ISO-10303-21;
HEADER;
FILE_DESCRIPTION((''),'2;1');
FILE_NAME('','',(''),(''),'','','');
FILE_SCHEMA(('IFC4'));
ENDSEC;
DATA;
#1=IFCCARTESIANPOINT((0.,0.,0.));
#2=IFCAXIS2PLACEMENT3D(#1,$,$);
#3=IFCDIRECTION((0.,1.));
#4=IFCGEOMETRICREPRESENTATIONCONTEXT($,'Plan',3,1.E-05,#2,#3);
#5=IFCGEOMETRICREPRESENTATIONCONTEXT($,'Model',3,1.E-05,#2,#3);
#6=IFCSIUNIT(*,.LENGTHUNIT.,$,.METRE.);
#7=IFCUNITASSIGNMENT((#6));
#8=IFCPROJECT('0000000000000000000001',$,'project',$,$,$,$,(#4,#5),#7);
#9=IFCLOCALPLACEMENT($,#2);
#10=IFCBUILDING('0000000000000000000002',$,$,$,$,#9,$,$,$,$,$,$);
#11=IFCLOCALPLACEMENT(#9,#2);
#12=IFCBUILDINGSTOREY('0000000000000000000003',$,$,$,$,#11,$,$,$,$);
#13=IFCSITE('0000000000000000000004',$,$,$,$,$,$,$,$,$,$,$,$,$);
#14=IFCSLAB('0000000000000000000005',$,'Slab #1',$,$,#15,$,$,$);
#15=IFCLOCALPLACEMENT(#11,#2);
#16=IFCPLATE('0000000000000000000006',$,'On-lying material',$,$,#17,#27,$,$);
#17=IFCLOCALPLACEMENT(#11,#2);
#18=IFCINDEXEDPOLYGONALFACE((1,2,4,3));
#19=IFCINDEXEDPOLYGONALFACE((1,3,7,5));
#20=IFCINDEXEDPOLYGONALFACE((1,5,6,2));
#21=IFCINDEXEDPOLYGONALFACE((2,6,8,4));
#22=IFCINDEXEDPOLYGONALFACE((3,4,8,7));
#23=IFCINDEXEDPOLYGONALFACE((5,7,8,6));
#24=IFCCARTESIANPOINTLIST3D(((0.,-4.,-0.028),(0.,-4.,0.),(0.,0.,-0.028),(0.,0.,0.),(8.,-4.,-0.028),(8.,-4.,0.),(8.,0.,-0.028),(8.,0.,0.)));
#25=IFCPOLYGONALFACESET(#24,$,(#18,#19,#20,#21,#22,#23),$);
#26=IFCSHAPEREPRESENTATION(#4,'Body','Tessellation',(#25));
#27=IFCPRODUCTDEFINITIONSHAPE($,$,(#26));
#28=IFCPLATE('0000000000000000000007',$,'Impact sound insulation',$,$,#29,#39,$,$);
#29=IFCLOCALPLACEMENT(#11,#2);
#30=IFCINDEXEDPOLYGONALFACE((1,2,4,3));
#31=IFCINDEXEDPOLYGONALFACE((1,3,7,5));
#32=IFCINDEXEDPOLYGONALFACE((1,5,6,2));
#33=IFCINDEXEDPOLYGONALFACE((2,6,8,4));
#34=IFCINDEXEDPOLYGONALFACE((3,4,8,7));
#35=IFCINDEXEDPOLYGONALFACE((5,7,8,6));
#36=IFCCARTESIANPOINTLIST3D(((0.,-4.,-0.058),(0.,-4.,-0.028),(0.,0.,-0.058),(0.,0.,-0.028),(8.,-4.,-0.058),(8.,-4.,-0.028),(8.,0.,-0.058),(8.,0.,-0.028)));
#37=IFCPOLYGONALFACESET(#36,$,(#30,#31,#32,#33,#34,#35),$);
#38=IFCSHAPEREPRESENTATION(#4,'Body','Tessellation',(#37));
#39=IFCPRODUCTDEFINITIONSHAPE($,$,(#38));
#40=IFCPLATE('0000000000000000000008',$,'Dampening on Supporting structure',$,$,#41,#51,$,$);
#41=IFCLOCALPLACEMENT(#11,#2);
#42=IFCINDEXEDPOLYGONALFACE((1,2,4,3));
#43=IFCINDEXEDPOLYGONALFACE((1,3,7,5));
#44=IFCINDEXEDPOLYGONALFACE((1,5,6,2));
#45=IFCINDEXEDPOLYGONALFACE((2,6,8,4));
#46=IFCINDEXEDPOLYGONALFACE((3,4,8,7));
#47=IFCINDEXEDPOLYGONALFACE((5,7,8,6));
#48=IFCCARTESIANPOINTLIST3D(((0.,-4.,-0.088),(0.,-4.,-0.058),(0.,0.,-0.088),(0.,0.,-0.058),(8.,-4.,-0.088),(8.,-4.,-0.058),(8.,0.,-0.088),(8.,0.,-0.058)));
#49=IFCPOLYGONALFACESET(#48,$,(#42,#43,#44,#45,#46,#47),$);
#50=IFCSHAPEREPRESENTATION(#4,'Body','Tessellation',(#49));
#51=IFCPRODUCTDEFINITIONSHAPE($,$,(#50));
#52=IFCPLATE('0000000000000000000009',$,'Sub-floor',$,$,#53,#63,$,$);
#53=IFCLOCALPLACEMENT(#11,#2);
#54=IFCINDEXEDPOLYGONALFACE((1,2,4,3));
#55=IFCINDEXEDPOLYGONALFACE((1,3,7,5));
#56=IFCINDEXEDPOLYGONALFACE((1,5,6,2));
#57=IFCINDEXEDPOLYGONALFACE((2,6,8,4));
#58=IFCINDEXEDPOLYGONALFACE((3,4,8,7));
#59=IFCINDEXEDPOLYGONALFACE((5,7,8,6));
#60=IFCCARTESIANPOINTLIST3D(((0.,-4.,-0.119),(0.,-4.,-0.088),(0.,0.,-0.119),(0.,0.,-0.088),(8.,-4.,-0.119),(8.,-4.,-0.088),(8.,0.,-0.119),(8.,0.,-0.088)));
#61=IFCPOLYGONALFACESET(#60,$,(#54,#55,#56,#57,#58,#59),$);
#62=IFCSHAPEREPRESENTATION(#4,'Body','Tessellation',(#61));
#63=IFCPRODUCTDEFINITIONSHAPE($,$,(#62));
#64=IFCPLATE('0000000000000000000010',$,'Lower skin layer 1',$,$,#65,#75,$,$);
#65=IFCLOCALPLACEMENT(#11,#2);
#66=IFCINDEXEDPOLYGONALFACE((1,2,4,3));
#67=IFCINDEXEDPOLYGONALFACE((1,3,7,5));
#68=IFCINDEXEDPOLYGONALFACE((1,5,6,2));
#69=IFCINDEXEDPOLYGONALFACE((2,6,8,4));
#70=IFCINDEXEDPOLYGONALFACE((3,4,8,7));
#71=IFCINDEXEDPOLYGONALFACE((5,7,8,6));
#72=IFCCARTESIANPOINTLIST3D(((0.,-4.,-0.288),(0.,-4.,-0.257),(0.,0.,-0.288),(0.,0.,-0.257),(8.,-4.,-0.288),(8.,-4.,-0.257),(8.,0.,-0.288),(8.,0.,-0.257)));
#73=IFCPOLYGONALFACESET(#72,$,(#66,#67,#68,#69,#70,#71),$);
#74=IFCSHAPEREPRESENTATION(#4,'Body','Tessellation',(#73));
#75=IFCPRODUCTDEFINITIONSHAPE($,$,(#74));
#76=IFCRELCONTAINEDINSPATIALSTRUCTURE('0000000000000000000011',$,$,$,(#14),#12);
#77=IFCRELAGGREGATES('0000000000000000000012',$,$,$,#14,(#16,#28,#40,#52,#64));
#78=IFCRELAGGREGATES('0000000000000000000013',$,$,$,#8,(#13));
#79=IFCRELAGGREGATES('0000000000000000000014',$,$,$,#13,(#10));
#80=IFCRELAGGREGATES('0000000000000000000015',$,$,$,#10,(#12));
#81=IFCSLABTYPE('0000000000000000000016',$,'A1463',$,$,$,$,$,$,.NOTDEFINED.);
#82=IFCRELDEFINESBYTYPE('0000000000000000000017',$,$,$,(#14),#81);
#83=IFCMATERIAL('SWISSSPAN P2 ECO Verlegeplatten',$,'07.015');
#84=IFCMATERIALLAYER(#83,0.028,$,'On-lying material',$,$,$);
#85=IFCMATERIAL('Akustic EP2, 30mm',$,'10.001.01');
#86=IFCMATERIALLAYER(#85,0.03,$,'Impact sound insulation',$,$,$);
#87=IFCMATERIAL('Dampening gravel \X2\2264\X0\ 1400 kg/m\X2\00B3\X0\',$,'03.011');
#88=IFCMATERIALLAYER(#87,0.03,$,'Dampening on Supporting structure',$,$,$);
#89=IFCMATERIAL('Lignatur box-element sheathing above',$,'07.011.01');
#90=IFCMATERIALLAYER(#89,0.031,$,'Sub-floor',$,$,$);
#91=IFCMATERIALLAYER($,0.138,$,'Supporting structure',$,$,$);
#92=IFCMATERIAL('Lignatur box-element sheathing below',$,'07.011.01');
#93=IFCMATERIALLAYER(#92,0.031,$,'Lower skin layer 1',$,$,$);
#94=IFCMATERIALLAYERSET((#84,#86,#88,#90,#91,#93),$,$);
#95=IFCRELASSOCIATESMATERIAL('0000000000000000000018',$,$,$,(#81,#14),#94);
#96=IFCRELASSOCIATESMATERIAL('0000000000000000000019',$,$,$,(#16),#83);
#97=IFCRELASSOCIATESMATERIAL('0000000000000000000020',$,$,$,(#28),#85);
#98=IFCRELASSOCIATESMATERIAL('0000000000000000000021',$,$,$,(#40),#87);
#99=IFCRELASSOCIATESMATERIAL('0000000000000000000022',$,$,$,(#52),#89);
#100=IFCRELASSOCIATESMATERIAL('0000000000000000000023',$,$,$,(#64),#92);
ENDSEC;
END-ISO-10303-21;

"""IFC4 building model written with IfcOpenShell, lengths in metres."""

from ifc_helpers import new_model, si_unit, direction, frame, frame_2d, origin, origin_with_axes, place, context, project, spatial, rectangle, extrude, material, layer, layer_set, type_object, element, aggregate, save


model = new_model("IFC4")

# Units and contexts
plan_context = context("Plan", 3, precision=1e-05, world=origin(), true_north=direction((0.0, 1.0)))
model_context = context("Model", 3, precision=1e-05, world=origin(), true_north=direction((0.0, 1.0)))
ifc_project = project(units=[si_unit("LENGTHUNIT", "METRE")], contexts=[plan_context, model_context])

# Site, building, storey
site = spatial("IfcSite", under=ifc_project)
building_placement = place(None, origin())
building = spatial("IfcBuilding", under=site, at=building_placement)
storey_placement = place(building_placement, origin())
storey = spatial("IfcBuildingStorey", under=building, at=storey_placement)

# Slab, plates
ifc_material_1 = material(Name="SWISSSPAN P2 ECO Verlegeplatten", Category="07.015")
ifc_layer_1 = layer(ifc_material_1, 0.028, Name="On-lying material")
ifc_material_2 = material(Name="Akustic EP2, 30mm", Category="10.001.01")
ifc_layer_2 = layer(ifc_material_2, 0.03, Name="Impact sound insulation")
ifc_material_3 = material(Name="Dampening gravel ≤ 1400 kg/m³", Category="03.011")
ifc_layer_3 = layer(ifc_material_3, 0.03, Name="Dampening on Supporting structure")
ifc_material_4 = material(Name="Lignatur box-element sheathing above", Category="07.011.01")
ifc_layer_4 = layer(ifc_material_4, 0.031, Name="Sub-floor")
ifc_layer_5 = layer(None, 0.138, Name="Supporting structure")
ifc_material_5 = material(Name="Lignatur box-element sheathing below", Category="07.011.01")
ifc_layer_6 = layer(ifc_material_5, 0.031, Name="Lower skin layer 1")
ifc_layer_set = layer_set([ifc_layer_1, ifc_layer_2, ifc_layer_3, ifc_layer_4, ifc_layer_5, ifc_layer_6])
slab_type = type_object("IfcSlabType", Name="A1463", PredefinedType="NOTDEFINED", material=ifc_layer_set)
slab_placement = place(None, frame((0.0, 0.0, 0.0), z_axis=(0.0, 0.0, -1.0), x_axis=(1.0, 0.0, 0.0)))
slab = element("IfcSlab", 1, at=slab_placement, inside=storey, type_object=slab_type, material=ifc_layer_set, Name="Slab #1")
plate_1_placement = place(slab_placement, origin())
plate_1 = element("IfcPlate", 2, at=plate_1_placement, material=ifc_material_1, Name="On-lying material", context=plan_context, shape_type="SweptSolid", body=[
    extrude(rectangle(XDim=8.0, YDim=4.0, at=frame_2d((4.0, 2.0), x_axis=(1.0, 0.0))), origin_with_axes(), (0.0, 0.0, 1.0), 0.028),
])
plate_2_placement = place(slab_placement, origin())
plate_2 = element("IfcPlate", 3, at=plate_2_placement, material=ifc_material_2, Name="Impact sound insulation", context=plan_context, shape_type="SweptSolid", body=[
    extrude(rectangle(XDim=8.0, YDim=4.0, at=frame_2d((4.0, 2.0), x_axis=(1.0, 0.0))), frame((0.0, 0.0, 0.028), z_axis=(0.0, 0.0, 1.0), x_axis=(1.0, 0.0, 0.0)), (0.0, 0.0, 1.0), 0.03),
])
plate_3_placement = place(slab_placement, origin())
plate_3 = element("IfcPlate", 4, at=plate_3_placement, material=ifc_material_3, Name="Dampening on Supporting structure", context=plan_context, shape_type="SweptSolid", body=[
    extrude(rectangle(XDim=8.0, YDim=4.0, at=frame_2d((4.0, 2.0), x_axis=(1.0, 0.0))), frame((0.0, 0.0, 0.058), z_axis=(0.0, 0.0, 1.0), x_axis=(1.0, 0.0, 0.0)), (0.0, 0.0, 1.0), 0.03),
])
plate_4_placement = place(slab_placement, origin())
plate_4 = element("IfcPlate", 5, at=plate_4_placement, material=ifc_material_4, Name="Sub-floor", context=plan_context, shape_type="SweptSolid", body=[
    extrude(rectangle(XDim=8.0, YDim=4.0, at=frame_2d((4.0, 2.0), x_axis=(1.0, 0.0))), frame((0.0, 0.0, 0.088), z_axis=(0.0, 0.0, 1.0), x_axis=(1.0, 0.0, 0.0)), (0.0, 0.0, 1.0), 0.031),
])
plate_5_placement = place(slab_placement, origin())
plate_5 = element("IfcPlate", 6, at=plate_5_placement, material=ifc_material_5, Name="Lower skin layer 1", context=plan_context, shape_type="SweptSolid", body=[
    extrude(rectangle(XDim=8.0, YDim=4.0, at=frame_2d((4.0, 2.0), x_axis=(1.0, 0.0))), frame((0.0, 0.0, 0.257), z_axis=(0.0, 0.0, 1.0), x_axis=(1.0, 0.0, 0.0)), (0.0, 0.0, 1.0), 0.031),
])
aggregate(slab, [plate_1, plate_2, plate_3, plate_4, plate_5])

save(model, "model.ifc")
